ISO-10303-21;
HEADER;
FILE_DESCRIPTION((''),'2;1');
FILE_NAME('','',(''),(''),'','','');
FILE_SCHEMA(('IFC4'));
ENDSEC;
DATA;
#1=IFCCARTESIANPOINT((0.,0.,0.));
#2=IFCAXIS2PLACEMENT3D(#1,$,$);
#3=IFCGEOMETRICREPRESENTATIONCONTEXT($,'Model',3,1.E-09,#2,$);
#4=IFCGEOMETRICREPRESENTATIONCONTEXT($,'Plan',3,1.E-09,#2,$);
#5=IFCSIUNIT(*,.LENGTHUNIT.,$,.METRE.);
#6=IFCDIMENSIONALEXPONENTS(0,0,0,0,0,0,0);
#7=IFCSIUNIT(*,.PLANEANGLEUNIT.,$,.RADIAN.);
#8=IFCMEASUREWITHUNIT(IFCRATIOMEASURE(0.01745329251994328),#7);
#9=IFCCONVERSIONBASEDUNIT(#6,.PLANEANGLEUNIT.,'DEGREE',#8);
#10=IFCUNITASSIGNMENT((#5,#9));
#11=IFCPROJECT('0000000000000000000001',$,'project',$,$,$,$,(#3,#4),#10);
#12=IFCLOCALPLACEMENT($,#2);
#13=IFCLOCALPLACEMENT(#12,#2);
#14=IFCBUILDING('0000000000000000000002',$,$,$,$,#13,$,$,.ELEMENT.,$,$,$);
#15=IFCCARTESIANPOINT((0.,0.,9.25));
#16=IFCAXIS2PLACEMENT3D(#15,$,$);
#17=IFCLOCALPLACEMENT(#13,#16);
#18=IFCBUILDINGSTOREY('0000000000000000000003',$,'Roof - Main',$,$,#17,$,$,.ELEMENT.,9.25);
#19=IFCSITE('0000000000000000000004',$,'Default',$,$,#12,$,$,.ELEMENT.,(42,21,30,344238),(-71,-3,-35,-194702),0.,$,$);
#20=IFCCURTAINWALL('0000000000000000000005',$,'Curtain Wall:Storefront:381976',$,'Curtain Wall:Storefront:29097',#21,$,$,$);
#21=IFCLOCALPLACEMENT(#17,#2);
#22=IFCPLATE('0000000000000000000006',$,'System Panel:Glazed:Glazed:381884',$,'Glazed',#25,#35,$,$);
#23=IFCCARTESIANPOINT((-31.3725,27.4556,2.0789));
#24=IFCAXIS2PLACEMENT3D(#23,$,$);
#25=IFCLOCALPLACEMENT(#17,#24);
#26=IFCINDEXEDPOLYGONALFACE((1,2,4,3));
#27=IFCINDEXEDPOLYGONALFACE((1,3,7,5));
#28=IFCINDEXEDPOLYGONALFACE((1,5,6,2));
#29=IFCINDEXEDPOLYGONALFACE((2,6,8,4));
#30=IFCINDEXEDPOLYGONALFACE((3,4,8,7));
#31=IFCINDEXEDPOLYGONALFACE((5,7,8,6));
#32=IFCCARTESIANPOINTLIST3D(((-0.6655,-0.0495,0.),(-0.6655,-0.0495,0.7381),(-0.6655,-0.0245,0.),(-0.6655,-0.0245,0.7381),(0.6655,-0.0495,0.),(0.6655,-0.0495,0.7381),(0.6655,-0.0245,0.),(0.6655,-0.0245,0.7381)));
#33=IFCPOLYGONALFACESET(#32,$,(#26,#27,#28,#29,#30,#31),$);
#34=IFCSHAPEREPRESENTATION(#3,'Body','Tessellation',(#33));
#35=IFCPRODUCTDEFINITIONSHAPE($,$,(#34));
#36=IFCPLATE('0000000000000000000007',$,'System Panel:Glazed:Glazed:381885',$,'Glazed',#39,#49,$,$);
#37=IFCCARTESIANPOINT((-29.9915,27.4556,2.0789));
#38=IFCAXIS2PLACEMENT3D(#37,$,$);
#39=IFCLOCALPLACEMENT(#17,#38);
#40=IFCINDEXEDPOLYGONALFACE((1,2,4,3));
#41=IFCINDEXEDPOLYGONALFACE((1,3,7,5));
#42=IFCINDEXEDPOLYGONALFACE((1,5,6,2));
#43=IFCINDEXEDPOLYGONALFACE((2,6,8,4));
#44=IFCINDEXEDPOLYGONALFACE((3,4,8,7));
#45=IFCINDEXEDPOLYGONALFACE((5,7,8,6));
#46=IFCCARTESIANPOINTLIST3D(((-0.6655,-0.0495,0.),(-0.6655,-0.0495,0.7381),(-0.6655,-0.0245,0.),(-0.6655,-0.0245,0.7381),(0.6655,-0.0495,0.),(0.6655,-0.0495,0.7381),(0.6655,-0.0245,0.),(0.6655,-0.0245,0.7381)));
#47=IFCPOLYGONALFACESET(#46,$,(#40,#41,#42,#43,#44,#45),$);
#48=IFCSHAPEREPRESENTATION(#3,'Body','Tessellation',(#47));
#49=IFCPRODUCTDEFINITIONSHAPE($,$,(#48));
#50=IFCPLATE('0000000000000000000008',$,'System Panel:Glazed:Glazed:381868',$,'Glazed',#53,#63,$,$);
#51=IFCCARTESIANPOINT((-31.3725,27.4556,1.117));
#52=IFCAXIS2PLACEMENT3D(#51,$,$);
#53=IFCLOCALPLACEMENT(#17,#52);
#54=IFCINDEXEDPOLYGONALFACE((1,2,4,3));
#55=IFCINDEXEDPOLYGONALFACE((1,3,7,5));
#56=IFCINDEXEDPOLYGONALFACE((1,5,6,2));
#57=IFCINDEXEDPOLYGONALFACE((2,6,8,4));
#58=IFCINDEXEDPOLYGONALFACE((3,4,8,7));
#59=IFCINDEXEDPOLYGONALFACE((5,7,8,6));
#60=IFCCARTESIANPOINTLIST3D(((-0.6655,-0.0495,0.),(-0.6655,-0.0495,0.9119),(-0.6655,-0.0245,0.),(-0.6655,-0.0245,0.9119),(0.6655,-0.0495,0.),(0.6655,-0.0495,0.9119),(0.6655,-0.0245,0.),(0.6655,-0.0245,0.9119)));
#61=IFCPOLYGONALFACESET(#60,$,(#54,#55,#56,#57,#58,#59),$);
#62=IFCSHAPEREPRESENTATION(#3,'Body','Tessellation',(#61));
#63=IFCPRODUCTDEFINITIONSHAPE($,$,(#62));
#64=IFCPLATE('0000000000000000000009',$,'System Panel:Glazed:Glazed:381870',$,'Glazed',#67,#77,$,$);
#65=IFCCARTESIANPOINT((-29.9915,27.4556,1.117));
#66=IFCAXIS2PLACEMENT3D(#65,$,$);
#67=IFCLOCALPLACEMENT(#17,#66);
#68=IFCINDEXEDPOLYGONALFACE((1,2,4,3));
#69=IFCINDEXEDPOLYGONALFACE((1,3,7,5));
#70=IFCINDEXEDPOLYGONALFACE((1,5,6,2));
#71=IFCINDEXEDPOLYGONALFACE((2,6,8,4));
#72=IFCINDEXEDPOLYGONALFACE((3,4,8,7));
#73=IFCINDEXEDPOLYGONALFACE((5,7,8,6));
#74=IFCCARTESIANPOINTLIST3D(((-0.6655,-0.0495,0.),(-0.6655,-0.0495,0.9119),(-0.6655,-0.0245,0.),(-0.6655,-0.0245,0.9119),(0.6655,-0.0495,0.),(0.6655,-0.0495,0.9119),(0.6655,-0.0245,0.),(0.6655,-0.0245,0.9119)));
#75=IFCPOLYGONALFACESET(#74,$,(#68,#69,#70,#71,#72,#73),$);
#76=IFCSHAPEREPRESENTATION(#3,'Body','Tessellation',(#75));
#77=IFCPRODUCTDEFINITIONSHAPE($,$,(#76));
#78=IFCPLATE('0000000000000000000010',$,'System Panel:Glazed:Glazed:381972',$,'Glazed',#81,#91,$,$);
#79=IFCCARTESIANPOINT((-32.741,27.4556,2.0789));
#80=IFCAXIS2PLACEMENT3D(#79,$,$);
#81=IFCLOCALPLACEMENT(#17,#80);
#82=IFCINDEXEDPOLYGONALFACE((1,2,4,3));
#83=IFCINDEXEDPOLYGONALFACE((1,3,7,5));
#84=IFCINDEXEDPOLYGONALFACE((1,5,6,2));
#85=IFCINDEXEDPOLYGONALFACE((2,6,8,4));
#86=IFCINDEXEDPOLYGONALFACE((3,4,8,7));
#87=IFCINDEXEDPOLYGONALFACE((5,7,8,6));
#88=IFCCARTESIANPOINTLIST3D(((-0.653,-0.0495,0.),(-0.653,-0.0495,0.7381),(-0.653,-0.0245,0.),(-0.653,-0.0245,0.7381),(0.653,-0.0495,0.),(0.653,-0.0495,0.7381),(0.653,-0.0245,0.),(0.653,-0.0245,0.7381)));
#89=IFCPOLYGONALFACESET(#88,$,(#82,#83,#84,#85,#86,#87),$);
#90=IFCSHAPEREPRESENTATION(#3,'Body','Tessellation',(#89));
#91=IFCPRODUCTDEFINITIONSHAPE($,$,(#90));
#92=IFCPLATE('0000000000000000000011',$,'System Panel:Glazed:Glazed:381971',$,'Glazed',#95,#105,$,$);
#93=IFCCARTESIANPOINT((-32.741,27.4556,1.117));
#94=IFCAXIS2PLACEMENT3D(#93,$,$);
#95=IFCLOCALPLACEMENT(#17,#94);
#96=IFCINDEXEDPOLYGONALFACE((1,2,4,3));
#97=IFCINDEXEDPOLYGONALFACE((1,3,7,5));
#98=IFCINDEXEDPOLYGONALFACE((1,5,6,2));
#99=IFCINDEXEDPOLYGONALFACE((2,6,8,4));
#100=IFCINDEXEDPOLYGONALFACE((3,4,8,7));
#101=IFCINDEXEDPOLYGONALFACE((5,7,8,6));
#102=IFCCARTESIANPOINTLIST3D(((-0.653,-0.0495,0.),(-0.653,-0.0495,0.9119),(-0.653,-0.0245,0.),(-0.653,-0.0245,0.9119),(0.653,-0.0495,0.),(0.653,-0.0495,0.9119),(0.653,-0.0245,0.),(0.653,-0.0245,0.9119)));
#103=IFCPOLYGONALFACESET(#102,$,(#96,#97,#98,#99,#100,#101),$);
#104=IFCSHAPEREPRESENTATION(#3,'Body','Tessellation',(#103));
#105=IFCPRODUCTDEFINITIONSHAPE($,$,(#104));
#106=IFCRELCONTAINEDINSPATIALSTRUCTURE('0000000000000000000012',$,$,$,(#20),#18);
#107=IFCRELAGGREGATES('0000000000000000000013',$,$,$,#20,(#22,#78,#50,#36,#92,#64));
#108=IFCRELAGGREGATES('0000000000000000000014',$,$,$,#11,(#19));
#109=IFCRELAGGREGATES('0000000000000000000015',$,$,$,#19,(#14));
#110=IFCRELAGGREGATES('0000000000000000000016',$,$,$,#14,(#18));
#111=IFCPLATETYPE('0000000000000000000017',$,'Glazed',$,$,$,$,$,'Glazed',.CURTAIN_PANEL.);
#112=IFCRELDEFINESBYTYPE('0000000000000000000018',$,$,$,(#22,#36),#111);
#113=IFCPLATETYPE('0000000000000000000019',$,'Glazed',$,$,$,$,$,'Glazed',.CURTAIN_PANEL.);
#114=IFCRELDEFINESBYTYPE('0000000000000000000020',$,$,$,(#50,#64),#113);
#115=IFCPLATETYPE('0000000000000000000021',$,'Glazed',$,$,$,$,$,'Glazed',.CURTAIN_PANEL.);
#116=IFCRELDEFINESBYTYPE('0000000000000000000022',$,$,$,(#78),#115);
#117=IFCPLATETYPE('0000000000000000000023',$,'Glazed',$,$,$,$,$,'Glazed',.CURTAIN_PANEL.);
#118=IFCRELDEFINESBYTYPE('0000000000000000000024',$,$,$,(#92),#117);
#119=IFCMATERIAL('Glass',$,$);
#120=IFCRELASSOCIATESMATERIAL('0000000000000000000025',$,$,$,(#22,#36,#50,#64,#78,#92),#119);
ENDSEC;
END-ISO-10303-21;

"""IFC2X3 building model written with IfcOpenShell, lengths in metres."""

from ifc_helpers import new_model, entity, si_unit, converted_unit, frame, origin, origin_2d_with_axis, place, context, project, spatial, rectangle, extrude, source, transform, mapped, material, type_object, type_shapes, element, aggregate, save


model = new_model("IFC2X3")

# Units and contexts
model_context = context("Model", 3, precision=1e-09, world=origin())
plan_context = context("Plan", 3, precision=1e-09, world=origin())
ifc_project = project(units=[si_unit("LENGTHUNIT", "METRE"), converted_unit("PLANEANGLEUNIT", "DEGREE", entity("IfcRatioMeasure", 0.01745329251994328), si_unit("PLANEANGLEUNIT", "RADIAN"), dimensions=[0, 0, 0, 0, 0, 0, 0])], contexts=[model_context, plan_context])

# Site, building, storey
site_placement = place(None, origin())
site = spatial("IfcSite", under=ifc_project, at=site_placement, Name="Default", CompositionType="ELEMENT", RefLatitude=(42, 21, 30, 344238), RefLongitude=(-71, -3, -35, -194702), RefElevation=0.0)
building_placement = place(site_placement, origin())
building = spatial("IfcBuilding", under=site, at=building_placement, CompositionType="ELEMENT")
storey_placement = place(building_placement, frame((0.0, 0.0, 9.25)))
storey = spatial("IfcBuildingStorey", under=building, at=storey_placement, Name="Roof - Main", CompositionType="ELEMENT", Elevation=9.25)

# Curtain wall
curtain_wall_1_placement = place(storey_placement, origin())
curtain_wall_1 = element("IfcCurtainWall", 1, at=curtain_wall_1_placement, inside=storey, Name="Curtain Wall:Storefront:381976", ObjectType="Curtain Wall:Storefront:29097")

# Plates
ifc_material_1 = material(Name="Glass")
plate_type_1 = type_object("IfcPlateType", Name="Glazed", ElementType="Glazed", PredefinedType="CURTAIN_PANEL")
shared_shape_1 = source(origin(), model_context, "Body", "SweptSolid", [
    extrude(rectangle(XDim=0.025, YDim=1.331, at=origin_2d_with_axis()), frame((0.0, -0.037, 0.0), z_axis=(0.0, 0.0, 1.0), x_axis=(0.0, 1.0, 0.0)), (0.0, 0.0, 1.0), 0.7381),
])
type_shapes(plate_type_1, [shared_shape_1])
plate_1_placement = place(storey_placement, frame((-31.3725, 27.4556, 2.0789)))
plate_1 = element("IfcPlate", 2, at=plate_1_placement, type_object=plate_type_1, material=ifc_material_1, Name="System Panel:Glazed:Glazed:381884", ObjectType="Glazed", context=model_context, shape_type="MappedRepresentation", body=[
    mapped(shared_shape_1, transform((0.0, 0.0, 0.0), scale=1.0)),
])
plate_2_placement = place(storey_placement, frame((-29.9915, 27.4556, 2.0789)))
plate_2 = element("IfcPlate", 3, at=plate_2_placement, type_object=plate_type_1, material=ifc_material_1, Name="System Panel:Glazed:Glazed:381885", ObjectType="Glazed", context=model_context, shape_type="MappedRepresentation", body=[
    mapped(shared_shape_1, transform((0.0, 0.0, 0.0), scale=1.0)),
])
plate_type_2 = type_object("IfcPlateType", Name="Glazed", ElementType="Glazed", PredefinedType="CURTAIN_PANEL")
shared_shape_2 = source(origin(), model_context, "Body", "SweptSolid", [
    extrude(rectangle(XDim=0.025, YDim=1.331, at=origin_2d_with_axis()), frame((0.0, -0.037, 0.0), z_axis=(0.0, 0.0, 1.0), x_axis=(0.0, 1.0, 0.0)), (0.0, 0.0, 1.0), 0.9119),
])
type_shapes(plate_type_2, [shared_shape_2])
plate_3_placement = place(storey_placement, frame((-31.3725, 27.4556, 1.117)))
plate_3 = element("IfcPlate", 4, at=plate_3_placement, type_object=plate_type_2, material=ifc_material_1, Name="System Panel:Glazed:Glazed:381868", ObjectType="Glazed", context=model_context, shape_type="MappedRepresentation", body=[
    mapped(shared_shape_2, transform((0.0, 0.0, 0.0), scale=1.0)),
])
plate_4_placement = place(storey_placement, frame((-29.9915, 27.4556, 1.117)))
plate_4 = element("IfcPlate", 5, at=plate_4_placement, type_object=plate_type_2, material=ifc_material_1, Name="System Panel:Glazed:Glazed:381870", ObjectType="Glazed", context=model_context, shape_type="MappedRepresentation", body=[
    mapped(shared_shape_2, transform((0.0, 0.0, 0.0), scale=1.0)),
])
plate_type_3 = type_object("IfcPlateType", Name="Glazed", ElementType="Glazed", PredefinedType="CURTAIN_PANEL")
shared_shape_3 = source(origin(), model_context, "Body", "SweptSolid", [
    extrude(rectangle(XDim=0.025, YDim=1.306, at=origin_2d_with_axis()), frame((0.0, -0.037, 0.0), z_axis=(0.0, 0.0, 1.0), x_axis=(0.0, 1.0, 0.0)), (0.0, 0.0, 1.0), 0.7381),
])
type_shapes(plate_type_3, [shared_shape_3])
plate_5_placement = place(storey_placement, frame((-32.741, 27.4556, 2.0789)))
plate_5 = element("IfcPlate", 6, at=plate_5_placement, type_object=plate_type_3, material=ifc_material_1, Name="System Panel:Glazed:Glazed:381972", ObjectType="Glazed", context=model_context, shape_type="MappedRepresentation", body=[
    mapped(shared_shape_3, transform((0.0, 0.0, 0.0), scale=1.0)),
])
plate_type_4 = type_object("IfcPlateType", Name="Glazed", ElementType="Glazed", PredefinedType="CURTAIN_PANEL")
shared_shape_4 = source(origin(), model_context, "Body", "SweptSolid", [
    extrude(rectangle(XDim=0.025, YDim=1.306, at=origin_2d_with_axis()), frame((0.0, -0.037, 0.0), z_axis=(0.0, 0.0, 1.0), x_axis=(0.0, 1.0, 0.0)), (0.0, 0.0, 1.0), 0.9119),
])
type_shapes(plate_type_4, [shared_shape_4])
plate_6_placement = place(storey_placement, frame((-32.741, 27.4556, 1.117)))
plate_6 = element("IfcPlate", 7, at=plate_6_placement, type_object=plate_type_4, material=ifc_material_1, Name="System Panel:Glazed:Glazed:381971", ObjectType="Glazed", context=model_context, shape_type="MappedRepresentation", body=[
    mapped(shared_shape_4, transform((0.0, 0.0, 0.0), scale=1.0)),
])
aggregate(curtain_wall_1, [plate_1, plate_5, plate_3, plate_2, plate_6, plate_4])

save(model, "model.ifc")
